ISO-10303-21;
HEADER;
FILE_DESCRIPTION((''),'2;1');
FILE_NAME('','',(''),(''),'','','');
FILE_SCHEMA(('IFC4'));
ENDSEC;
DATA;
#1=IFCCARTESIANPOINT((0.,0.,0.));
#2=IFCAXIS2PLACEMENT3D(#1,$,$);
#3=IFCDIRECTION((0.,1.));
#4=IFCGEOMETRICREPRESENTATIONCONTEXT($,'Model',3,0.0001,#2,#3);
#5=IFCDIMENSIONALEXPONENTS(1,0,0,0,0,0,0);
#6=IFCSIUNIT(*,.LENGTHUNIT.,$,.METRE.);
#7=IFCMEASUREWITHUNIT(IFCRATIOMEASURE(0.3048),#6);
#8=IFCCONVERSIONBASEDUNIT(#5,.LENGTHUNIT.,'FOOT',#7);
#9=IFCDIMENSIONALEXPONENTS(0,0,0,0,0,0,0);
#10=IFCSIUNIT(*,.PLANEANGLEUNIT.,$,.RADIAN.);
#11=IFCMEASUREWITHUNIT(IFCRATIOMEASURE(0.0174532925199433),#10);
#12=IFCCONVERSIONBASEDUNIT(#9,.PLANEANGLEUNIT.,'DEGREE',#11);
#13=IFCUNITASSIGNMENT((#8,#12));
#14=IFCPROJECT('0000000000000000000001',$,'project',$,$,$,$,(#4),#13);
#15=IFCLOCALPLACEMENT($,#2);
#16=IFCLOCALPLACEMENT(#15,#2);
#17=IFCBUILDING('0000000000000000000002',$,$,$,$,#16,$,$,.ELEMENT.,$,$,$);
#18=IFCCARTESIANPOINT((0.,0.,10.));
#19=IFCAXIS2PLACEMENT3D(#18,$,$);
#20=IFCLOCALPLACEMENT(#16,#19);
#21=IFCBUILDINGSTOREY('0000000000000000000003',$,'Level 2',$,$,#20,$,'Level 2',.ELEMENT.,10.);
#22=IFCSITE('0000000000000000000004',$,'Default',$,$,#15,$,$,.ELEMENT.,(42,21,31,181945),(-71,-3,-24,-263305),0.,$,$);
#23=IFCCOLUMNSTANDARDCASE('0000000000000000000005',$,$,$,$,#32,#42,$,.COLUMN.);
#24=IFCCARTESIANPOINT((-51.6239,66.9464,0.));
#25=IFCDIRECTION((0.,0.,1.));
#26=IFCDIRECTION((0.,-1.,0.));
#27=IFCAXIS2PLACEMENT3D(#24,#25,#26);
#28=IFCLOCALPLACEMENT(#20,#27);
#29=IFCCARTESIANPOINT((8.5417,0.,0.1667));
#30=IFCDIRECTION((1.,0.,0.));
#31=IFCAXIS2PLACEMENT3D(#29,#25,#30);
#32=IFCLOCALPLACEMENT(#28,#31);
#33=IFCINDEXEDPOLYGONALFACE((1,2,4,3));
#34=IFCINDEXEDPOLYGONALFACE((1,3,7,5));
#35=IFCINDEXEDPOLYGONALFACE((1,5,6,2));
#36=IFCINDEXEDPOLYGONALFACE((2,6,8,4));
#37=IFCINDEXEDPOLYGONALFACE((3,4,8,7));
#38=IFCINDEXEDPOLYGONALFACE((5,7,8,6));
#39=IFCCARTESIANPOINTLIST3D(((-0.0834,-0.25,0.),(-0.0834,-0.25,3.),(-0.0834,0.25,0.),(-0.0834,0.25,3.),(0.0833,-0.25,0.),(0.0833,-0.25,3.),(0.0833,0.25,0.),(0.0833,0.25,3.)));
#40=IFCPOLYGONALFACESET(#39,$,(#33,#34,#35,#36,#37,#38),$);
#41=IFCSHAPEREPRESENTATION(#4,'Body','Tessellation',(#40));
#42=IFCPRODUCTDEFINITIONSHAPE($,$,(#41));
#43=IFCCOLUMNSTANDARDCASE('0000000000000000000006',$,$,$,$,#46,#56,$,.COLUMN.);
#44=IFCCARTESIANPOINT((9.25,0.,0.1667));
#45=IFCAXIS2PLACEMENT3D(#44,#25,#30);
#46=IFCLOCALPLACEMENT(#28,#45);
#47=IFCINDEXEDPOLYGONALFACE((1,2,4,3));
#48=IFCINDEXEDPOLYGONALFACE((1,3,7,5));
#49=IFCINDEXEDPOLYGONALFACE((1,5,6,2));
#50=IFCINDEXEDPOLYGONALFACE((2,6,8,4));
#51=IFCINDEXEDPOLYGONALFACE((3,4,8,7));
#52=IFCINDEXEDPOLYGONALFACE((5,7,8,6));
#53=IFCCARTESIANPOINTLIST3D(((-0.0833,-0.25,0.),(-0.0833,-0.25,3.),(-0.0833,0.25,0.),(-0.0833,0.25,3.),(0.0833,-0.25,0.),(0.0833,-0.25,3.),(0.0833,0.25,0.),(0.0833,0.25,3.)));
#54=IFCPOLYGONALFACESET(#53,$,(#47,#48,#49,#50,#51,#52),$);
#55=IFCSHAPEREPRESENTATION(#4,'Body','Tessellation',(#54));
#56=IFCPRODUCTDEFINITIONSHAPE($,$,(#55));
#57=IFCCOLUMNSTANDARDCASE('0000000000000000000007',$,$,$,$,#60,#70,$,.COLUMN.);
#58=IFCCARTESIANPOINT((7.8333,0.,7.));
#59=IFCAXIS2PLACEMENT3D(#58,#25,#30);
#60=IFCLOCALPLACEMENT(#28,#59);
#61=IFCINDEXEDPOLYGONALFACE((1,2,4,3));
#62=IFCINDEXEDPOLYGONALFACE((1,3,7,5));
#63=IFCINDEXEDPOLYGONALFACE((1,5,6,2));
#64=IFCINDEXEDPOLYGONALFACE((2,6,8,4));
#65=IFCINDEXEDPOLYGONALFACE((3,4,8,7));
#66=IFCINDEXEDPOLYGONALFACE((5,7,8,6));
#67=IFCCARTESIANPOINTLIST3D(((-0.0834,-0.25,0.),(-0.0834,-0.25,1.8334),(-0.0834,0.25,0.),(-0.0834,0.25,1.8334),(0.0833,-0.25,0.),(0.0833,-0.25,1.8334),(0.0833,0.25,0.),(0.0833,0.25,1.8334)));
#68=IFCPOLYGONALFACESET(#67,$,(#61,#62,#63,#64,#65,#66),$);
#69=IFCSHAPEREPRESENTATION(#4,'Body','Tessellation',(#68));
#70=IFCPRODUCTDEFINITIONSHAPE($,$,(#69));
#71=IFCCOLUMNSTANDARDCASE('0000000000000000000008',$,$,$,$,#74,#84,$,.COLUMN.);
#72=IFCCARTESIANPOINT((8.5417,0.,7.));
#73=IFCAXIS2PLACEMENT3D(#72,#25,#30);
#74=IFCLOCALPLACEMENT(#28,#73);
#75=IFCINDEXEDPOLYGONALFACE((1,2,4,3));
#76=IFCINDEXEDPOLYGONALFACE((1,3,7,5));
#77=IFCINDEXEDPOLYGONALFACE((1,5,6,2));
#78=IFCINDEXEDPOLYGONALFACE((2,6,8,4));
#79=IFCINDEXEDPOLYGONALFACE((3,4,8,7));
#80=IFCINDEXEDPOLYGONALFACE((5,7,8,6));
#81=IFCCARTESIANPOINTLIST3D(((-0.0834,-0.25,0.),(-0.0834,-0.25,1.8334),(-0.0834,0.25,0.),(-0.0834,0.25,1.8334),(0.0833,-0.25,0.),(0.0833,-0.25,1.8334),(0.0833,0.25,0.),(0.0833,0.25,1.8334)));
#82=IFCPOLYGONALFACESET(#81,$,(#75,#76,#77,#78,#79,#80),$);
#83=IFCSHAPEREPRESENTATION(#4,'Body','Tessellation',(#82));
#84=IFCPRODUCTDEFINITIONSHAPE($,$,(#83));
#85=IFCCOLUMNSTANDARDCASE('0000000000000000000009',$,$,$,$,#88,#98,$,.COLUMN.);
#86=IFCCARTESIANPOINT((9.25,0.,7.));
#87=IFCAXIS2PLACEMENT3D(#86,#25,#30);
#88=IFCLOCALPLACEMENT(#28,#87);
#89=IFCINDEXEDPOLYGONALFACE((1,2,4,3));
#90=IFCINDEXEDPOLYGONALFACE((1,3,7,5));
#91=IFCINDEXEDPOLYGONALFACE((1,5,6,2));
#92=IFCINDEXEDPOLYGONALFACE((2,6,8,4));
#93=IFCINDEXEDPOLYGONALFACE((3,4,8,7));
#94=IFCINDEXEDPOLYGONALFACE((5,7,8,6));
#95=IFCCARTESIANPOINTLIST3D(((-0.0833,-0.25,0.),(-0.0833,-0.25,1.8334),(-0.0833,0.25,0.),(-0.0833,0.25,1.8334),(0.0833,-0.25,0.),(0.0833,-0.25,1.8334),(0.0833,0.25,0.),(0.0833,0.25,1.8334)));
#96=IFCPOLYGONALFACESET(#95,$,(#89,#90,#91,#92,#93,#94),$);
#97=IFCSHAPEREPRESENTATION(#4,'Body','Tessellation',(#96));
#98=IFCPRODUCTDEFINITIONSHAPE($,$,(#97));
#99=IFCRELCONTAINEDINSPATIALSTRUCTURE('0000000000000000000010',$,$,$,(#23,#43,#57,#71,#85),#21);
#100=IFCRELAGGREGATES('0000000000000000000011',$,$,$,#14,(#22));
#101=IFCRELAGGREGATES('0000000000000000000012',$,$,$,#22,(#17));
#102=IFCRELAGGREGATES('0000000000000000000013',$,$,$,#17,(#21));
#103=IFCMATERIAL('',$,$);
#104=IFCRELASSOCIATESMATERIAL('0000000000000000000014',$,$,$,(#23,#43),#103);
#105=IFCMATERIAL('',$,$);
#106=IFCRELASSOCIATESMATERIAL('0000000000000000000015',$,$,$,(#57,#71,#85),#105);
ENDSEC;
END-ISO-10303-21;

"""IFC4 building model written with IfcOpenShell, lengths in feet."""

from ifc_helpers import new_model, entity, si_unit, converted_unit, direction, frame, origin, place, context, project, spatial, rectangle, extrude, material, element, save


model = new_model("IFC4")

# Units and contexts
model_context = context("Model", 3, precision=0.0001, world=origin(), true_north=direction((0.0, 1.0)))
ifc_project = project(units=[converted_unit("LENGTHUNIT", "FOOT", entity("IfcRatioMeasure", 0.3048), si_unit("LENGTHUNIT", "METRE"), dimensions=[1, 0, 0, 0, 0, 0, 0]), converted_unit("PLANEANGLEUNIT", "DEGREE", entity("IfcRatioMeasure", 0.0174532925199433), si_unit("PLANEANGLEUNIT", "RADIAN"), dimensions=[0, 0, 0, 0, 0, 0, 0])], contexts=[model_context])

# Site, building, storey
site_placement = place(None, origin())
site = spatial("IfcSite", under=ifc_project, at=site_placement, Name="Default", CompositionType="ELEMENT", RefLatitude=(42, 21, 31, 181945), RefLongitude=(-71, -3, -24, -263305), RefElevation=0.0)
building_placement = place(site_placement, origin())
building = spatial("IfcBuilding", under=site, at=building_placement, CompositionType="ELEMENT")
storey_placement = place(building_placement, frame((0.0, 0.0, 10.0)))
storey = spatial("IfcBuildingStorey", under=building, at=storey_placement, Name="Level 2", LongName="Level 2", CompositionType="ELEMENT", Elevation=10.0)

# Columns
placement = place(storey_placement, frame((-51.6239, 66.9464, 0.0), z_axis=(0.0, 0.0, 1.0), x_axis=(0.0, -1.0, 0.0)))
ifc_material_1 = material(Name="")
for number, where, z_axis, x_axis in (
    (1, (8.5417, 0.0, 0.1667), (0.0, 0.0, 1.0), (1.0, 0.0, 0.0)),
    (2, (9.25, 0.0, 0.1667), (0.0, 0.0, 1.0), (1.0, 0.0, 0.0)),
):
    element("IfcColumnStandardCase", number, at=place(placement, frame(where, z_axis=z_axis, x_axis=x_axis)), inside=storey, material=ifc_material_1, PredefinedType="COLUMN", context=model_context, shape_type="SweptSolid", body=[
        extrude(rectangle(XDim=0.1667, YDim=0.5), origin(), (0.0, 0.0, 1.0), 3.0),
    ])
ifc_material_2 = material(Name="")
for number, where, z_axis, x_axis in (
    (3, (7.8333, 0.0, 7.0), (0.0, 0.0, 1.0), (1.0, 0.0, 0.0)),
    (4, (8.5417, 0.0, 7.0), (0.0, 0.0, 1.0), (1.0, 0.0, 0.0)),
    (5, (9.25, 0.0, 7.0), (0.0, 0.0, 1.0), (1.0, 0.0, 0.0)),
):
    element("IfcColumnStandardCase", number, at=place(placement, frame(where, z_axis=z_axis, x_axis=x_axis)), inside=storey, material=ifc_material_2, PredefinedType="COLUMN", context=model_context, shape_type="SweptSolid", body=[
        extrude(rectangle(XDim=0.1667, YDim=0.5), origin(), (0.0, 0.0, 1.0), 1.8334),
    ])

save(model, "model.ifc")
